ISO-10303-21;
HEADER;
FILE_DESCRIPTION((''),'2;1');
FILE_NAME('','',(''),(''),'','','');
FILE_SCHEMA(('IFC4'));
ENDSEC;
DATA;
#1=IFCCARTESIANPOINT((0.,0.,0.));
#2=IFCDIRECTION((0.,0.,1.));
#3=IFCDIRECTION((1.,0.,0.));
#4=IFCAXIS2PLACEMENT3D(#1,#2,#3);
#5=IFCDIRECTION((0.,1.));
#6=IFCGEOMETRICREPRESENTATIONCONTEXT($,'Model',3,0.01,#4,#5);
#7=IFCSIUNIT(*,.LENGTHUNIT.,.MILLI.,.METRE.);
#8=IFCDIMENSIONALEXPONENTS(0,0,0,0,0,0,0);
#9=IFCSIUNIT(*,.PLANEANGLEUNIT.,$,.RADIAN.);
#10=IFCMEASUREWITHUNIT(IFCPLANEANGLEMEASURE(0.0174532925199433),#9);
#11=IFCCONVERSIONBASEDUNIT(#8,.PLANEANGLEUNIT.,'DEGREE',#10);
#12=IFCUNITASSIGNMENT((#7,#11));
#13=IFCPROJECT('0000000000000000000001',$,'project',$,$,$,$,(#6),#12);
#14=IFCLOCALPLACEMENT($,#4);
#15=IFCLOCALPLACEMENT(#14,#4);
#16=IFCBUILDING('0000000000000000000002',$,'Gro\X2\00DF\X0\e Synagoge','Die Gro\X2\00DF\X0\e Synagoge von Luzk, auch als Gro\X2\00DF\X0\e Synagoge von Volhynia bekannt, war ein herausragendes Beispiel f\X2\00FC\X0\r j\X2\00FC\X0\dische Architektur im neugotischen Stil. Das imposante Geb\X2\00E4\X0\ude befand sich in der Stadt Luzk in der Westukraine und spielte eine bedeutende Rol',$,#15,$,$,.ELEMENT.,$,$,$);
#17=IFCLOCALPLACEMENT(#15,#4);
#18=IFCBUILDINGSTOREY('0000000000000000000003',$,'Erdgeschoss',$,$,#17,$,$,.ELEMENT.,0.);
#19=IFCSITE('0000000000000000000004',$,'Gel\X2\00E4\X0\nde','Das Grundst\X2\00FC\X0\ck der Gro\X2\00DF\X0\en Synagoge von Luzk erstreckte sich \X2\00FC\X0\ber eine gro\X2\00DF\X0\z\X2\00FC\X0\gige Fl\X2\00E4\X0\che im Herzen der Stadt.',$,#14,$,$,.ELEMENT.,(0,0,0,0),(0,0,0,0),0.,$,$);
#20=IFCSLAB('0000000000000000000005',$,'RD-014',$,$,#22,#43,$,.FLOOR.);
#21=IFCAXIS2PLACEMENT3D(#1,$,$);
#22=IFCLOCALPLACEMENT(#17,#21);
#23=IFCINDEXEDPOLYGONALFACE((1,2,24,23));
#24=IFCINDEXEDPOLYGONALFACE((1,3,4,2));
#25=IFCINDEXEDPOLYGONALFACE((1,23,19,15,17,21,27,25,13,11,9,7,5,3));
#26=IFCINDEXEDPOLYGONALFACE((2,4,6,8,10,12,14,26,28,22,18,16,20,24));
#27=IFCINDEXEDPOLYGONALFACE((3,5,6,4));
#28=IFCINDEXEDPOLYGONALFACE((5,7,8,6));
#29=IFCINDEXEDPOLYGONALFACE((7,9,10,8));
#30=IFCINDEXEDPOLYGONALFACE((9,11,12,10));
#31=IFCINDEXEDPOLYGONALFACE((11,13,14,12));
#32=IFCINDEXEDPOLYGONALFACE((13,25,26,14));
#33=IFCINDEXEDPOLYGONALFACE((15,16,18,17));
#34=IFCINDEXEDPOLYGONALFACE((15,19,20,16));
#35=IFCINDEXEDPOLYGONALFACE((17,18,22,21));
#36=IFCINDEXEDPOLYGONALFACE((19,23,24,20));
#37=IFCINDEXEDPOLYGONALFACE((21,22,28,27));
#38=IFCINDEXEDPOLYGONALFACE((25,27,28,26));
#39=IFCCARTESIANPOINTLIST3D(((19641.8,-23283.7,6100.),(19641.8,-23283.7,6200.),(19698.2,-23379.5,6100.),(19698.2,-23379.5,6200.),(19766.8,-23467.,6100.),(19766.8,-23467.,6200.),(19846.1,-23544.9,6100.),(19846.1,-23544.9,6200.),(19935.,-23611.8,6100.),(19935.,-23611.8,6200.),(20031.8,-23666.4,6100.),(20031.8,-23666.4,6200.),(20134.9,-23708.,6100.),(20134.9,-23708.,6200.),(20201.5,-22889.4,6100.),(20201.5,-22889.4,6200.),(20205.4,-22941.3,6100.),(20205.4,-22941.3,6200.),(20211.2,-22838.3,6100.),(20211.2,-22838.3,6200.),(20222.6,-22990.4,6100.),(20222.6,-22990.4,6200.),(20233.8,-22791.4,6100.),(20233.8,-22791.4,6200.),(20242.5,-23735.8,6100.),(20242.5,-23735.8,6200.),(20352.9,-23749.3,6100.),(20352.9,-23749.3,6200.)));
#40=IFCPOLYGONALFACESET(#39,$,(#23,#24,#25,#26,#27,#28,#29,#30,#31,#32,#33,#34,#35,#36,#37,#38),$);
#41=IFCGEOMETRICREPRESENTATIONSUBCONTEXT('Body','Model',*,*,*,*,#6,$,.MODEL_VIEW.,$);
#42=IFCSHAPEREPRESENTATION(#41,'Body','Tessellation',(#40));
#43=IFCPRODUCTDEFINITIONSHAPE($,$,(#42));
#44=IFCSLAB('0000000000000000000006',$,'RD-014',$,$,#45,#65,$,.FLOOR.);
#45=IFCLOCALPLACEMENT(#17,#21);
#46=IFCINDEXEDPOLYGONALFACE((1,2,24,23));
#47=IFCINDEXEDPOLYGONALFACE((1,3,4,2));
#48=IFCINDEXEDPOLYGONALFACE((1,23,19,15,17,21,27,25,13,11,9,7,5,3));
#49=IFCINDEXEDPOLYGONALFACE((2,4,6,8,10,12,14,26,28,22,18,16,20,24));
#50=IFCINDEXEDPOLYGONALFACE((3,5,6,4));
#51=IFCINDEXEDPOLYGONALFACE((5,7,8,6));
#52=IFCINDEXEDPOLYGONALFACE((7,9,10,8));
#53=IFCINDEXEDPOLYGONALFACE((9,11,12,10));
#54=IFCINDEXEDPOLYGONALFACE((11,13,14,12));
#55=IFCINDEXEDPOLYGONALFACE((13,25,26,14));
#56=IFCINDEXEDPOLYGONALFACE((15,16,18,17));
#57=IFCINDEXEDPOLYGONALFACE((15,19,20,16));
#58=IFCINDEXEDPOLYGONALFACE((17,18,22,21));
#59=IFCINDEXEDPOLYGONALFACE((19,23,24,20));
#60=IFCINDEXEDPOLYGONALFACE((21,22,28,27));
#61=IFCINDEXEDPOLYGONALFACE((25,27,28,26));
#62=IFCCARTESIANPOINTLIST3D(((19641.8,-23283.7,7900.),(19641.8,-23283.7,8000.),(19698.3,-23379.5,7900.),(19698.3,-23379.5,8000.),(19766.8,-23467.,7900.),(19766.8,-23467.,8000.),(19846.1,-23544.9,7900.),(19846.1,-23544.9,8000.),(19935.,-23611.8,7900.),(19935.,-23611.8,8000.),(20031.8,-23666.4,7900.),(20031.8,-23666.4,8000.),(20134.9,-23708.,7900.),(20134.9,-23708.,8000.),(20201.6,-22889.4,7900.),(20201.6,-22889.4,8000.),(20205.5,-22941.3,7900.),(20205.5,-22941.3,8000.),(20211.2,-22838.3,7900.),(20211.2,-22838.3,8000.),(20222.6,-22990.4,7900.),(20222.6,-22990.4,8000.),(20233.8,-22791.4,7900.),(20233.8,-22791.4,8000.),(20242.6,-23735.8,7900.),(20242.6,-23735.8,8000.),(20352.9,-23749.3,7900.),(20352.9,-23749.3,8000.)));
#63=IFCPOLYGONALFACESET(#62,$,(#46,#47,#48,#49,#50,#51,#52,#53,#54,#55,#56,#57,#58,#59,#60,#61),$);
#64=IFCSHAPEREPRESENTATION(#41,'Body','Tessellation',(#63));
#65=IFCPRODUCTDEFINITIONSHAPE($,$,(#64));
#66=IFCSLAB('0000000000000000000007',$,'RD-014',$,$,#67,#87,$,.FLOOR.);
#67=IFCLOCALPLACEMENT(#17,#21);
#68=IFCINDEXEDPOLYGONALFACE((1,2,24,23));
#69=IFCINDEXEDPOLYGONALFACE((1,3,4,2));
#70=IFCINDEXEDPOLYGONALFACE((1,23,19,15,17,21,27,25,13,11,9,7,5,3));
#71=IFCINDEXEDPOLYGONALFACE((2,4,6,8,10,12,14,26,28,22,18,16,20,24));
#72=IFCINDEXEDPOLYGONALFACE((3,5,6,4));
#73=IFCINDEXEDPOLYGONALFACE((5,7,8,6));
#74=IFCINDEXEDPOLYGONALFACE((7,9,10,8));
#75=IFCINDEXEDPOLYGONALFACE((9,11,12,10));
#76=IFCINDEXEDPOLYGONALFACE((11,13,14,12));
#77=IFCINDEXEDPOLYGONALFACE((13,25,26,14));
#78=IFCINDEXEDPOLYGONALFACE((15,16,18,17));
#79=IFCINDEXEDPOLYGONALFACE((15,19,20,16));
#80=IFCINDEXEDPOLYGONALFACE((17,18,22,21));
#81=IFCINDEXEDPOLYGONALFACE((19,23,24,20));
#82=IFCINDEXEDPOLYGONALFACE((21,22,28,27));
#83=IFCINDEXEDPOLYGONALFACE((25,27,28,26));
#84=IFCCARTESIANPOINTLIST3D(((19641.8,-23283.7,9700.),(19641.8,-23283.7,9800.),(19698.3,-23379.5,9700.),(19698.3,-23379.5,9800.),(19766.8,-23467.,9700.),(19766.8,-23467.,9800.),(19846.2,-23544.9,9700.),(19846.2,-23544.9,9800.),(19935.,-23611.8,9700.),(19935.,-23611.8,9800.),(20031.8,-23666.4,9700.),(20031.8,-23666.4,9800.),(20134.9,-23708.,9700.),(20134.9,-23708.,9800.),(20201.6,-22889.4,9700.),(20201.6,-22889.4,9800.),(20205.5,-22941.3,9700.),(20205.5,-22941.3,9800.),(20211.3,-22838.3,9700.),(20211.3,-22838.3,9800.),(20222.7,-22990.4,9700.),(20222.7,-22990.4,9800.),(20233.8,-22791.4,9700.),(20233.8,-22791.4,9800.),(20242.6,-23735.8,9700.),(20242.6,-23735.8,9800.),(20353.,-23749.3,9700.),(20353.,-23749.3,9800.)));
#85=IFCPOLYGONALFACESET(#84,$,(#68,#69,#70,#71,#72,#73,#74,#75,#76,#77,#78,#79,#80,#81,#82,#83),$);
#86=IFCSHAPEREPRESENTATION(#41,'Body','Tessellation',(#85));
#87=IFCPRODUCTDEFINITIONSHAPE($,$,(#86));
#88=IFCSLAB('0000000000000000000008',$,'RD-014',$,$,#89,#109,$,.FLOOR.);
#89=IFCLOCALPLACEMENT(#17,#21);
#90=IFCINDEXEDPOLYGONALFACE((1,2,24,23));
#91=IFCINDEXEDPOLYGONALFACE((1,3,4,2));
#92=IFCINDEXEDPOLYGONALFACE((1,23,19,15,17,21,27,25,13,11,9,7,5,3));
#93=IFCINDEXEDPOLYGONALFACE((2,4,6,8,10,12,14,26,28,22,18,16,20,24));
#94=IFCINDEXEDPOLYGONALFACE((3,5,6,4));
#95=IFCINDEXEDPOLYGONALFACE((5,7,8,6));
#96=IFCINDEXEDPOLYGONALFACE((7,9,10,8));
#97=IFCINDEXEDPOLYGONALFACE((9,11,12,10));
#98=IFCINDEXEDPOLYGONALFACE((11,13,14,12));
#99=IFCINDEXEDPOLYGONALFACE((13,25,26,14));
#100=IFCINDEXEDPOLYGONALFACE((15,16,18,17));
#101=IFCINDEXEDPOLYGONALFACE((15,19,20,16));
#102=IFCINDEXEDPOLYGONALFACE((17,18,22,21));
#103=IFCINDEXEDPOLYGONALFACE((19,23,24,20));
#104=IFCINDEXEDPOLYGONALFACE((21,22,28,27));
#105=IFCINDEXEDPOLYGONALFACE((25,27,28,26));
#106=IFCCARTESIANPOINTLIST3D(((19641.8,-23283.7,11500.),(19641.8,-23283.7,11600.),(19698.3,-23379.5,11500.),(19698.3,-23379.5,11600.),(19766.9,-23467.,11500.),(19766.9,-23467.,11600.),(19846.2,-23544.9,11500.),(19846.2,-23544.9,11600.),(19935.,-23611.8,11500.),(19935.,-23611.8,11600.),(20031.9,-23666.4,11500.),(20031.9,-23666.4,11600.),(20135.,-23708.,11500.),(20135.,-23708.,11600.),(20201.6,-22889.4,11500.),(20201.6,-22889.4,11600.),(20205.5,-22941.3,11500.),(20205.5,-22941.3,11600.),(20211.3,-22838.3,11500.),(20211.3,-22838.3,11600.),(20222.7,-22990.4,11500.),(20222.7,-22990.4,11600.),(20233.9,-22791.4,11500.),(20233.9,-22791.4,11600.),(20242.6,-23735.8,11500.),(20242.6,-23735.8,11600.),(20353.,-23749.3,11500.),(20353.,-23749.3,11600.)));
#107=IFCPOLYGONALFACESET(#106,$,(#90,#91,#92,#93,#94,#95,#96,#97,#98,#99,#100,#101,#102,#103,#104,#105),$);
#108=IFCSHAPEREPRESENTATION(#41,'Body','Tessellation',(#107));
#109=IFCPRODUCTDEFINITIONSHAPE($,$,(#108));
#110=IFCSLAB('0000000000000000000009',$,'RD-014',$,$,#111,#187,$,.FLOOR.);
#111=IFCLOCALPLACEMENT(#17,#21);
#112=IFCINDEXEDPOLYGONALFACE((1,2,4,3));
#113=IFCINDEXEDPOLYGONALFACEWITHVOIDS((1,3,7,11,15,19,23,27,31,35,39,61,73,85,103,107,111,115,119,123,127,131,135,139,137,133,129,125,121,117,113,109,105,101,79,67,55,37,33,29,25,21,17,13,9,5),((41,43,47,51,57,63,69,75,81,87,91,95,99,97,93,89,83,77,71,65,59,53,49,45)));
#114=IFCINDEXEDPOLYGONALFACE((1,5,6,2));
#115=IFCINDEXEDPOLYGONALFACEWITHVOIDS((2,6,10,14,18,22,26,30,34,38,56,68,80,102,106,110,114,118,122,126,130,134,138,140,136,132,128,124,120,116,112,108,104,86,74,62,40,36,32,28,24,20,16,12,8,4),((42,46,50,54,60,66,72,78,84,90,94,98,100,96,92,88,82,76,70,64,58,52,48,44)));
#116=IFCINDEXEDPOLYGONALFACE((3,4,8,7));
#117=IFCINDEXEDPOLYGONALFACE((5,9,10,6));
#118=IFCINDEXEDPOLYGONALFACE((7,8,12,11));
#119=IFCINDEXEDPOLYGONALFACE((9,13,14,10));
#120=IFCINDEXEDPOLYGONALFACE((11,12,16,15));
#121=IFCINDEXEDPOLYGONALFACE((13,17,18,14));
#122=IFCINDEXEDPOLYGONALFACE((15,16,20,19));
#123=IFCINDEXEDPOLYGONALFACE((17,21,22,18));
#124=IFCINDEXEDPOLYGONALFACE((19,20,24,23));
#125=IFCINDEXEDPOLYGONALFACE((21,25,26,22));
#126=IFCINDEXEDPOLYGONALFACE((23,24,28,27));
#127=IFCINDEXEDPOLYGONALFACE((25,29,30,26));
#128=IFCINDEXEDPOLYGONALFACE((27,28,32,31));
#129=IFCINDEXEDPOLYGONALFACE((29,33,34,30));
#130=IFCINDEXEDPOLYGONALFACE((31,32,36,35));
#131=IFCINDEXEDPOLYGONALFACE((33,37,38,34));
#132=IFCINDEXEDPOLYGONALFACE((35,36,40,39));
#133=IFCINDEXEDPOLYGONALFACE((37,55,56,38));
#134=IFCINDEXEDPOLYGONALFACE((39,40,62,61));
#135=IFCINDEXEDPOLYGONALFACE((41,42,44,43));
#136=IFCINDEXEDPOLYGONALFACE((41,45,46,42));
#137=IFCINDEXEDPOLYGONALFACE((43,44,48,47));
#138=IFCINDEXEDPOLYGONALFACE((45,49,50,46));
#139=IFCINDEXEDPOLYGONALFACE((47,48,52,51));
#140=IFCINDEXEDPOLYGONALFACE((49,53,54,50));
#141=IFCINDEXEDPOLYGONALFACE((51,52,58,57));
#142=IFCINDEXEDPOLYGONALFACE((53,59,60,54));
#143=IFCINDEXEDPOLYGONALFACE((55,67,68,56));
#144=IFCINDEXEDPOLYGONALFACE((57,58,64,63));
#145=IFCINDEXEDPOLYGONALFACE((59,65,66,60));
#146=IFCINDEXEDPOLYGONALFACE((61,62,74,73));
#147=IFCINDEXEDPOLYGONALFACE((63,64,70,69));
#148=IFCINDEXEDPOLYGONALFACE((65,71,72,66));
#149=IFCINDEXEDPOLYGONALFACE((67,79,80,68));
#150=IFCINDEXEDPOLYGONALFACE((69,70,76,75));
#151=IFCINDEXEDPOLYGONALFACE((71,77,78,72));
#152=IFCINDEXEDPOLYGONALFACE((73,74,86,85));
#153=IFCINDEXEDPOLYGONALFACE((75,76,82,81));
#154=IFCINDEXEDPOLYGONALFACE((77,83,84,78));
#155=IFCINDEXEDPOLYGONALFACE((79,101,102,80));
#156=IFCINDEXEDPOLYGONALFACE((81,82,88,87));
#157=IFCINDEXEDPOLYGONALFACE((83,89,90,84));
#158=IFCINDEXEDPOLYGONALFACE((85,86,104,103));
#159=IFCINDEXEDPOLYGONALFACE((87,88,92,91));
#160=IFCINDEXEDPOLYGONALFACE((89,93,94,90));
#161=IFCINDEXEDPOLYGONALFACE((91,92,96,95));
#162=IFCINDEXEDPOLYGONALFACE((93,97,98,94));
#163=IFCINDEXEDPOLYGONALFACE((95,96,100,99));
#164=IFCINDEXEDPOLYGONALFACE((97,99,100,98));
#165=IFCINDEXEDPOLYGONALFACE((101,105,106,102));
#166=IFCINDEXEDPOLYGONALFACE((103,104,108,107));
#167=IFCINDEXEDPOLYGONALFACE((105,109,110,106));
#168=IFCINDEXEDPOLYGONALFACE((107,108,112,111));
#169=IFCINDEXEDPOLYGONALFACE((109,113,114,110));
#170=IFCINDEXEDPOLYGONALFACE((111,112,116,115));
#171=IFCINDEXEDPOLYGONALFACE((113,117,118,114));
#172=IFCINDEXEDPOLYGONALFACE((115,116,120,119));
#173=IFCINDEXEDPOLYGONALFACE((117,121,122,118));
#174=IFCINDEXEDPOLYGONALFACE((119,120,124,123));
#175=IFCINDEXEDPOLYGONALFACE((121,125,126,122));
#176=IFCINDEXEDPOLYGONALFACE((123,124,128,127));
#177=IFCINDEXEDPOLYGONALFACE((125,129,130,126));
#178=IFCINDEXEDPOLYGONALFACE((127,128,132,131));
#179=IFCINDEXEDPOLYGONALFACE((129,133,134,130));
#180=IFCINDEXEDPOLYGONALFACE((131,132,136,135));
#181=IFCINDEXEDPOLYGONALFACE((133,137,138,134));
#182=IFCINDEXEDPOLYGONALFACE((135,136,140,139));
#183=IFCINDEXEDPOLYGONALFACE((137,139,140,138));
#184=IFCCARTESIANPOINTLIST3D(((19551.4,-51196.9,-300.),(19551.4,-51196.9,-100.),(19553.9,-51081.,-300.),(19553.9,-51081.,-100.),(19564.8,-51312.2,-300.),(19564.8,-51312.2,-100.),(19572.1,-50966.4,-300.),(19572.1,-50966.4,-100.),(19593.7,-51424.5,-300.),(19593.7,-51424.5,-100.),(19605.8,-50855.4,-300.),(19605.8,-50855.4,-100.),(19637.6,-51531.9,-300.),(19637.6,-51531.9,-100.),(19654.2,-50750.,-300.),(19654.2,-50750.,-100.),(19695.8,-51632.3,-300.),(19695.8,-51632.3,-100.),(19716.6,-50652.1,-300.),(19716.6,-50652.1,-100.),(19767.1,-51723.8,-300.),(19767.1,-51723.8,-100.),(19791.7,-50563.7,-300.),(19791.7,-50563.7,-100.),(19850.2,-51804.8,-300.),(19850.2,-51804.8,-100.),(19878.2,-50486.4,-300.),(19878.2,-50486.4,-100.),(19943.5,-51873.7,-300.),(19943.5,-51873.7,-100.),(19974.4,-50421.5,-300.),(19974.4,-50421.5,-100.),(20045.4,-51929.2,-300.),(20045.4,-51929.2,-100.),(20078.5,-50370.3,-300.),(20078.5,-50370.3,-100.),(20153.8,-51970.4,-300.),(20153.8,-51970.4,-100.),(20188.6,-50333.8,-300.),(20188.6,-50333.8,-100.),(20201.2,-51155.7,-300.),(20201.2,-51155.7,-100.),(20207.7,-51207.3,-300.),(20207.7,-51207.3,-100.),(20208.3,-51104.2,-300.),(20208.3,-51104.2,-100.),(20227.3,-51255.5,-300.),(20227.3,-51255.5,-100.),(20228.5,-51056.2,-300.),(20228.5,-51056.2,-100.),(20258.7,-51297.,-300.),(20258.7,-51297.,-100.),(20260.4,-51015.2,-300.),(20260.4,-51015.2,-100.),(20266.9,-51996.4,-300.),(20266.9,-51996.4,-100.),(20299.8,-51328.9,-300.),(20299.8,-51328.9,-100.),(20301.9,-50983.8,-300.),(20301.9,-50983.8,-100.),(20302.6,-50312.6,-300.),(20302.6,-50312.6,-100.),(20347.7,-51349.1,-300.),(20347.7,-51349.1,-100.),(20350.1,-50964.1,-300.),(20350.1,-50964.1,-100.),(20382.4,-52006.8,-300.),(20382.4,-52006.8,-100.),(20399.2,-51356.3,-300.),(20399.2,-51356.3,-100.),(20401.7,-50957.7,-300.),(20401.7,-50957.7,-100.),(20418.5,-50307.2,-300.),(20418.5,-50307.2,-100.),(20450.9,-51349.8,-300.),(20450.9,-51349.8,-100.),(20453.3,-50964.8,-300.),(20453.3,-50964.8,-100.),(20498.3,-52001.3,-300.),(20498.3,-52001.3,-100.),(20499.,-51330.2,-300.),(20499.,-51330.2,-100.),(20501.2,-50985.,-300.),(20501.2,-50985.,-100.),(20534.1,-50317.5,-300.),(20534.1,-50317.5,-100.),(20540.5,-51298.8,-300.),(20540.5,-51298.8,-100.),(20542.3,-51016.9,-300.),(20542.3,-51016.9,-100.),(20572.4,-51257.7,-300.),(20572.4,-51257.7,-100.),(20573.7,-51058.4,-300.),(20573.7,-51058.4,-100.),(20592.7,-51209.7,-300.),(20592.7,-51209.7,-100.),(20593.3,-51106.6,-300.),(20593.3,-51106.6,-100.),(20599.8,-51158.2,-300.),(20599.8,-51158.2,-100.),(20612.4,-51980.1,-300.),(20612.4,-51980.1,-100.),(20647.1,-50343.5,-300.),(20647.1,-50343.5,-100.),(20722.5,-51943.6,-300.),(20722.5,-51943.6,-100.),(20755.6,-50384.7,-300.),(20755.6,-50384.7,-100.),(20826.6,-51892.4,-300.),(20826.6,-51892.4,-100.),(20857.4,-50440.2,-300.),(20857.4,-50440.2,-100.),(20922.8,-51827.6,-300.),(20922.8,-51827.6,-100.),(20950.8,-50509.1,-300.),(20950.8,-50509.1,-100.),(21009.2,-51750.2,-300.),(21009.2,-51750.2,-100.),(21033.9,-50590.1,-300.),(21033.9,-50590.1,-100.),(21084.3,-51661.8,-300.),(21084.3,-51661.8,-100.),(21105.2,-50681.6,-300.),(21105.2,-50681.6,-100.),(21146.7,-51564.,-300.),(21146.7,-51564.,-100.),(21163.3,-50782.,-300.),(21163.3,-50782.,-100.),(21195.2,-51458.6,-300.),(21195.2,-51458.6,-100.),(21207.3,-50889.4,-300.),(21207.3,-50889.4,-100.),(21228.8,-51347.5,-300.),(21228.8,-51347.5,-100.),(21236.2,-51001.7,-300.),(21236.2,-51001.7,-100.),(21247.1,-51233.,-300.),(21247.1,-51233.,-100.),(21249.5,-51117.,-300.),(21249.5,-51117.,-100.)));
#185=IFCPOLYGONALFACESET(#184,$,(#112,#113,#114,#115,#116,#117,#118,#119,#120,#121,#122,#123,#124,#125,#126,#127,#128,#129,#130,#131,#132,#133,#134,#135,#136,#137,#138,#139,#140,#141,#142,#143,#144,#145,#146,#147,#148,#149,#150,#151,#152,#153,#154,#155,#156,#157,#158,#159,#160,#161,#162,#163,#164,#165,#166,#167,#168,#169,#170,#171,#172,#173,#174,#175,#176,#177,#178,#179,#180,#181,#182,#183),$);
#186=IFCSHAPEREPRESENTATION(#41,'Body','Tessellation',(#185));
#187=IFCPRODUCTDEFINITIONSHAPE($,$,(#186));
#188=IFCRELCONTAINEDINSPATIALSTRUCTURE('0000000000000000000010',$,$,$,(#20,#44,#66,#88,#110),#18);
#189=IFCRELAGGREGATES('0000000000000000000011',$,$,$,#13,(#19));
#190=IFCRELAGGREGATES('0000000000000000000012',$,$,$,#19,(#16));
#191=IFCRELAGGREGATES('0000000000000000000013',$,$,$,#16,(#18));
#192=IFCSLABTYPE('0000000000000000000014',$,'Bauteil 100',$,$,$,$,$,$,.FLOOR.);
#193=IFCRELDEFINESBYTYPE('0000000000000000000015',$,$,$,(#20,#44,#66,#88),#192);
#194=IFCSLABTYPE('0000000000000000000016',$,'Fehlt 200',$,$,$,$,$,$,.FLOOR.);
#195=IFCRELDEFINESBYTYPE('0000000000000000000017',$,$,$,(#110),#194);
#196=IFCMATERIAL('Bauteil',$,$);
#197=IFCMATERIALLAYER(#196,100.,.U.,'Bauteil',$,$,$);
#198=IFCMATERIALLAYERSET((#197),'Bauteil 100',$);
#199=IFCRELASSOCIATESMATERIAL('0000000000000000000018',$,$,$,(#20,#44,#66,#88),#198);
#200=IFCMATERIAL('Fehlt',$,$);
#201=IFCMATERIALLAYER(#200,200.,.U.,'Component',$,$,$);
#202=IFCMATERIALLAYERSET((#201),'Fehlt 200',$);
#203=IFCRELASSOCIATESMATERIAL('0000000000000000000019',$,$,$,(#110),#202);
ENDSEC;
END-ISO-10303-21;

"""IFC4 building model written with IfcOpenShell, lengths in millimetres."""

from ifc_helpers import new_model, entity, si_unit, converted_unit, direction, frame, origin_with_axes, place, context, subcontext, project, spatial, line, arc, indexed_curve, outline, extrude, material, layer, layer_set, layer_usage, type_object, element, save


model = new_model("IFC4")

# Units and contexts
model_context = context("Model", 3, precision=0.01, world=origin_with_axes(), true_north=direction((0.0, 1.0)))
body_context = subcontext(model_context, "Body", "Model", "MODEL_VIEW")
ifc_project = project(units=[si_unit("LENGTHUNIT", "METRE", prefix="MILLI"), converted_unit("PLANEANGLEUNIT", "DEGREE", entity("IfcPlaneAngleMeasure", 0.0174532925199433), si_unit("PLANEANGLEUNIT", "RADIAN"), dimensions=[0, 0, 0, 0, 0, 0, 0])], contexts=[model_context])

# Site, building, storey
site_placement = place(None, origin_with_axes())
site = spatial("IfcSite", under=ifc_project, at=site_placement, Name="Gelände", Description="Das Grundstück der Großen Synagoge von Luzk erstreckte sich über eine großzügige Fläche im Herzen der Stadt.", CompositionType="ELEMENT", RefLatitude=(0, 0, 0, 0), RefLongitude=(0, 0, 0, 0), RefElevation=0.0)
building_placement = place(site_placement, origin_with_axes())
building = spatial("IfcBuilding", under=site, at=building_placement, Name="Große Synagoge", Description="Die Große Synagoge von Luzk, auch als Große Synagoge von Volhynia bekannt, war ein herausragendes Beispiel für jüdische Architektur im neugotischen Stil. Das imposante Gebäude befand sich in der Stadt Luzk in der Westukraine und spielte eine bedeutende Rol", CompositionType="ELEMENT")
storey_placement = place(building_placement, origin_with_axes())
storey = spatial("IfcBuildingStorey", under=building, at=storey_placement, Name="Erdgeschoss", CompositionType="ELEMENT", Elevation=0.0)

# Slabs
ifc_material_1 = material(Name="Bauteil")
ifc_layer_1 = layer(ifc_material_1, 100.0, ventilated="UNKNOWN", Name="Bauteil")
ifc_layer_set_1 = layer_set([ifc_layer_1], Name="Bauteil 100")
slab_type_1 = type_object("IfcSlabType", Name="Bauteil 100", PredefinedType="FLOOR")
ifc_layer_usage_1 = layer_usage(ifc_layer_set_1, "AXIS3", "NEGATIVE", 100.0)
slab_1_placement = place(storey_placement, frame((19641.8, -23283.7, 6200.0), z_axis=(0.0, 0.0, 1.0), x_axis=(1.0, 0.0, 0.0)))
element("IfcSlab", 1, at=slab_1_placement, inside=storey, type_object=slab_type_1, material=ifc_layer_usage_1, Name="RD-014", PredefinedType="FLOOR", context=body_context, shape_type="SweptSolid", body=[
    extrude(outline(indexed_curve([(0.0, 0.0), (293.2, -328.0), (711.2, -465.6), (580.9, 293.3), (559.8, 394.3), (592.0, 492.3)], segments=[arc(1, 2, 3), line(3, 4), arc(4, 5, 6), line(6, 1)])), frame((0.0, 0.0, -100.0), z_axis=(0.0, 0.0, 1.0), x_axis=(1.0, 0.0, 0.0)), (0.0, 0.0, 1.0), 100.0),
])
ifc_layer_usage_2 = layer_usage(ifc_layer_set_1, "AXIS3", "NEGATIVE", 100.0)
slab_2_placement = place(storey_placement, frame((19641.8, -23283.7, 8000.0), z_axis=(0.0, 0.0, 1.0), x_axis=(1.0, 0.0, 0.0)))
element("IfcSlab", 2, at=slab_2_placement, inside=storey, type_object=slab_type_1, material=ifc_layer_usage_2, Name="RD-014", PredefinedType="FLOOR", context=body_context, shape_type="SweptSolid", body=[
    extrude(outline(indexed_curve([(0.0, 0.0), (293.2, -328.0), (711.2, -465.6), (580.9, 293.3), (559.8, 394.3), (592.0, 492.3)], segments=[arc(1, 2, 3), line(3, 4), arc(4, 5, 6), line(6, 1)])), frame((0.0, 0.0, -100.0), z_axis=(0.0, 0.0, 1.0), x_axis=(1.0, 0.0, 0.0)), (0.0, 0.0, 1.0), 100.0),
])
ifc_layer_usage_3 = layer_usage(ifc_layer_set_1, "AXIS3", "NEGATIVE", 100.0)
slab_3_placement = place(storey_placement, frame((19641.8, -23283.7, 9800.0), z_axis=(0.0, 0.0, 1.0), x_axis=(1.0, 0.0, 0.0)))
element("IfcSlab", 3, at=slab_3_placement, inside=storey, type_object=slab_type_1, material=ifc_layer_usage_3, Name="RD-014", PredefinedType="FLOOR", context=body_context, shape_type="SweptSolid", body=[
    extrude(outline(indexed_curve([(0.0, 0.0), (293.2, -328.0), (711.2, -465.6), (580.9, 293.3), (559.8, 394.3), (592.0, 492.3)], segments=[arc(1, 2, 3), line(3, 4), arc(4, 5, 6), line(6, 1)])), frame((0.0, 0.0, -100.0), z_axis=(0.0, 0.0, 1.0), x_axis=(1.0, 0.0, 0.0)), (0.0, 0.0, 1.0), 100.0),
])
ifc_layer_usage_4 = layer_usage(ifc_layer_set_1, "AXIS3", "NEGATIVE", 100.0)
slab_4_placement = place(storey_placement, frame((19641.8, -23283.7, 11600.0), z_axis=(0.0, 0.0, 1.0), x_axis=(1.0, 0.0, 0.0)))
element("IfcSlab", 4, at=slab_4_placement, inside=storey, type_object=slab_type_1, material=ifc_layer_usage_4, Name="RD-014", PredefinedType="FLOOR", context=body_context, shape_type="SweptSolid", body=[
    extrude(outline(indexed_curve([(0.0, 0.0), (293.2, -328.0), (711.2, -465.6), (580.9, 293.3), (559.8, 394.3), (592.0, 492.3)], segments=[arc(1, 2, 3), line(3, 4), arc(4, 5, 6), line(6, 1)])), frame((0.0, 0.0, -100.0), z_axis=(0.0, 0.0, 1.0), x_axis=(1.0, 0.0, 0.0)), (0.0, 0.0, 1.0), 100.0),
])
ifc_material_2 = material(Name="Fehlt")
ifc_layer_2 = layer(ifc_material_2, 200.0, ventilated="UNKNOWN", Name="Component")
ifc_layer_set_2 = layer_set([ifc_layer_2], Name="Fehlt 200")
ifc_layer_usage_5 = layer_usage(ifc_layer_set_2, "AXIS3", "NEGATIVE", 200.0)
slab_type_2 = type_object("IfcSlabType", Name="Fehlt 200", PredefinedType="FLOOR")
slab_5_placement = place(storey_placement, frame((19716.6, -50652.1, -100.0), z_axis=(0.0, 0.0, 1.0), x_axis=(1.0, 0.0, 0.0)))
element("IfcSlab", 5, at=slab_5_placement, inside=storey, type_object=slab_type_2, material=ifc_layer_usage_5, Name="RD-014", PredefinedType="FLOOR", context=body_context, shape_type="SweptSolid", body=[
    extrude(outline(indexed_curve([(0.0, 0.0), (179.0, -1188.7), (1367.7, -1009.6), (1188.7, 179.0), (736.6, -312.6), (876.0, -557.6), (631.1, -697.0), (491.7, -452.0)], segments=[arc(1, 2, 3), arc(3, 4, 1)]), holes=[indexed_curve([(0.0, 0.0), (179.0, -1188.7), (1367.7, -1009.6), (1188.7, 179.0), (736.6, -312.6), (876.0, -557.6), (631.1, -697.0), (491.7, -452.0)], segments=[arc(5, 6, 7), arc(7, 8, 5)])]), frame((0.0, 0.0, -200.0), z_axis=(0.0, 0.0, 1.0), x_axis=(1.0, 0.0, 0.0)), (0.0, 0.0, 1.0), 200.0),
])

save(model, "model.ifc")
